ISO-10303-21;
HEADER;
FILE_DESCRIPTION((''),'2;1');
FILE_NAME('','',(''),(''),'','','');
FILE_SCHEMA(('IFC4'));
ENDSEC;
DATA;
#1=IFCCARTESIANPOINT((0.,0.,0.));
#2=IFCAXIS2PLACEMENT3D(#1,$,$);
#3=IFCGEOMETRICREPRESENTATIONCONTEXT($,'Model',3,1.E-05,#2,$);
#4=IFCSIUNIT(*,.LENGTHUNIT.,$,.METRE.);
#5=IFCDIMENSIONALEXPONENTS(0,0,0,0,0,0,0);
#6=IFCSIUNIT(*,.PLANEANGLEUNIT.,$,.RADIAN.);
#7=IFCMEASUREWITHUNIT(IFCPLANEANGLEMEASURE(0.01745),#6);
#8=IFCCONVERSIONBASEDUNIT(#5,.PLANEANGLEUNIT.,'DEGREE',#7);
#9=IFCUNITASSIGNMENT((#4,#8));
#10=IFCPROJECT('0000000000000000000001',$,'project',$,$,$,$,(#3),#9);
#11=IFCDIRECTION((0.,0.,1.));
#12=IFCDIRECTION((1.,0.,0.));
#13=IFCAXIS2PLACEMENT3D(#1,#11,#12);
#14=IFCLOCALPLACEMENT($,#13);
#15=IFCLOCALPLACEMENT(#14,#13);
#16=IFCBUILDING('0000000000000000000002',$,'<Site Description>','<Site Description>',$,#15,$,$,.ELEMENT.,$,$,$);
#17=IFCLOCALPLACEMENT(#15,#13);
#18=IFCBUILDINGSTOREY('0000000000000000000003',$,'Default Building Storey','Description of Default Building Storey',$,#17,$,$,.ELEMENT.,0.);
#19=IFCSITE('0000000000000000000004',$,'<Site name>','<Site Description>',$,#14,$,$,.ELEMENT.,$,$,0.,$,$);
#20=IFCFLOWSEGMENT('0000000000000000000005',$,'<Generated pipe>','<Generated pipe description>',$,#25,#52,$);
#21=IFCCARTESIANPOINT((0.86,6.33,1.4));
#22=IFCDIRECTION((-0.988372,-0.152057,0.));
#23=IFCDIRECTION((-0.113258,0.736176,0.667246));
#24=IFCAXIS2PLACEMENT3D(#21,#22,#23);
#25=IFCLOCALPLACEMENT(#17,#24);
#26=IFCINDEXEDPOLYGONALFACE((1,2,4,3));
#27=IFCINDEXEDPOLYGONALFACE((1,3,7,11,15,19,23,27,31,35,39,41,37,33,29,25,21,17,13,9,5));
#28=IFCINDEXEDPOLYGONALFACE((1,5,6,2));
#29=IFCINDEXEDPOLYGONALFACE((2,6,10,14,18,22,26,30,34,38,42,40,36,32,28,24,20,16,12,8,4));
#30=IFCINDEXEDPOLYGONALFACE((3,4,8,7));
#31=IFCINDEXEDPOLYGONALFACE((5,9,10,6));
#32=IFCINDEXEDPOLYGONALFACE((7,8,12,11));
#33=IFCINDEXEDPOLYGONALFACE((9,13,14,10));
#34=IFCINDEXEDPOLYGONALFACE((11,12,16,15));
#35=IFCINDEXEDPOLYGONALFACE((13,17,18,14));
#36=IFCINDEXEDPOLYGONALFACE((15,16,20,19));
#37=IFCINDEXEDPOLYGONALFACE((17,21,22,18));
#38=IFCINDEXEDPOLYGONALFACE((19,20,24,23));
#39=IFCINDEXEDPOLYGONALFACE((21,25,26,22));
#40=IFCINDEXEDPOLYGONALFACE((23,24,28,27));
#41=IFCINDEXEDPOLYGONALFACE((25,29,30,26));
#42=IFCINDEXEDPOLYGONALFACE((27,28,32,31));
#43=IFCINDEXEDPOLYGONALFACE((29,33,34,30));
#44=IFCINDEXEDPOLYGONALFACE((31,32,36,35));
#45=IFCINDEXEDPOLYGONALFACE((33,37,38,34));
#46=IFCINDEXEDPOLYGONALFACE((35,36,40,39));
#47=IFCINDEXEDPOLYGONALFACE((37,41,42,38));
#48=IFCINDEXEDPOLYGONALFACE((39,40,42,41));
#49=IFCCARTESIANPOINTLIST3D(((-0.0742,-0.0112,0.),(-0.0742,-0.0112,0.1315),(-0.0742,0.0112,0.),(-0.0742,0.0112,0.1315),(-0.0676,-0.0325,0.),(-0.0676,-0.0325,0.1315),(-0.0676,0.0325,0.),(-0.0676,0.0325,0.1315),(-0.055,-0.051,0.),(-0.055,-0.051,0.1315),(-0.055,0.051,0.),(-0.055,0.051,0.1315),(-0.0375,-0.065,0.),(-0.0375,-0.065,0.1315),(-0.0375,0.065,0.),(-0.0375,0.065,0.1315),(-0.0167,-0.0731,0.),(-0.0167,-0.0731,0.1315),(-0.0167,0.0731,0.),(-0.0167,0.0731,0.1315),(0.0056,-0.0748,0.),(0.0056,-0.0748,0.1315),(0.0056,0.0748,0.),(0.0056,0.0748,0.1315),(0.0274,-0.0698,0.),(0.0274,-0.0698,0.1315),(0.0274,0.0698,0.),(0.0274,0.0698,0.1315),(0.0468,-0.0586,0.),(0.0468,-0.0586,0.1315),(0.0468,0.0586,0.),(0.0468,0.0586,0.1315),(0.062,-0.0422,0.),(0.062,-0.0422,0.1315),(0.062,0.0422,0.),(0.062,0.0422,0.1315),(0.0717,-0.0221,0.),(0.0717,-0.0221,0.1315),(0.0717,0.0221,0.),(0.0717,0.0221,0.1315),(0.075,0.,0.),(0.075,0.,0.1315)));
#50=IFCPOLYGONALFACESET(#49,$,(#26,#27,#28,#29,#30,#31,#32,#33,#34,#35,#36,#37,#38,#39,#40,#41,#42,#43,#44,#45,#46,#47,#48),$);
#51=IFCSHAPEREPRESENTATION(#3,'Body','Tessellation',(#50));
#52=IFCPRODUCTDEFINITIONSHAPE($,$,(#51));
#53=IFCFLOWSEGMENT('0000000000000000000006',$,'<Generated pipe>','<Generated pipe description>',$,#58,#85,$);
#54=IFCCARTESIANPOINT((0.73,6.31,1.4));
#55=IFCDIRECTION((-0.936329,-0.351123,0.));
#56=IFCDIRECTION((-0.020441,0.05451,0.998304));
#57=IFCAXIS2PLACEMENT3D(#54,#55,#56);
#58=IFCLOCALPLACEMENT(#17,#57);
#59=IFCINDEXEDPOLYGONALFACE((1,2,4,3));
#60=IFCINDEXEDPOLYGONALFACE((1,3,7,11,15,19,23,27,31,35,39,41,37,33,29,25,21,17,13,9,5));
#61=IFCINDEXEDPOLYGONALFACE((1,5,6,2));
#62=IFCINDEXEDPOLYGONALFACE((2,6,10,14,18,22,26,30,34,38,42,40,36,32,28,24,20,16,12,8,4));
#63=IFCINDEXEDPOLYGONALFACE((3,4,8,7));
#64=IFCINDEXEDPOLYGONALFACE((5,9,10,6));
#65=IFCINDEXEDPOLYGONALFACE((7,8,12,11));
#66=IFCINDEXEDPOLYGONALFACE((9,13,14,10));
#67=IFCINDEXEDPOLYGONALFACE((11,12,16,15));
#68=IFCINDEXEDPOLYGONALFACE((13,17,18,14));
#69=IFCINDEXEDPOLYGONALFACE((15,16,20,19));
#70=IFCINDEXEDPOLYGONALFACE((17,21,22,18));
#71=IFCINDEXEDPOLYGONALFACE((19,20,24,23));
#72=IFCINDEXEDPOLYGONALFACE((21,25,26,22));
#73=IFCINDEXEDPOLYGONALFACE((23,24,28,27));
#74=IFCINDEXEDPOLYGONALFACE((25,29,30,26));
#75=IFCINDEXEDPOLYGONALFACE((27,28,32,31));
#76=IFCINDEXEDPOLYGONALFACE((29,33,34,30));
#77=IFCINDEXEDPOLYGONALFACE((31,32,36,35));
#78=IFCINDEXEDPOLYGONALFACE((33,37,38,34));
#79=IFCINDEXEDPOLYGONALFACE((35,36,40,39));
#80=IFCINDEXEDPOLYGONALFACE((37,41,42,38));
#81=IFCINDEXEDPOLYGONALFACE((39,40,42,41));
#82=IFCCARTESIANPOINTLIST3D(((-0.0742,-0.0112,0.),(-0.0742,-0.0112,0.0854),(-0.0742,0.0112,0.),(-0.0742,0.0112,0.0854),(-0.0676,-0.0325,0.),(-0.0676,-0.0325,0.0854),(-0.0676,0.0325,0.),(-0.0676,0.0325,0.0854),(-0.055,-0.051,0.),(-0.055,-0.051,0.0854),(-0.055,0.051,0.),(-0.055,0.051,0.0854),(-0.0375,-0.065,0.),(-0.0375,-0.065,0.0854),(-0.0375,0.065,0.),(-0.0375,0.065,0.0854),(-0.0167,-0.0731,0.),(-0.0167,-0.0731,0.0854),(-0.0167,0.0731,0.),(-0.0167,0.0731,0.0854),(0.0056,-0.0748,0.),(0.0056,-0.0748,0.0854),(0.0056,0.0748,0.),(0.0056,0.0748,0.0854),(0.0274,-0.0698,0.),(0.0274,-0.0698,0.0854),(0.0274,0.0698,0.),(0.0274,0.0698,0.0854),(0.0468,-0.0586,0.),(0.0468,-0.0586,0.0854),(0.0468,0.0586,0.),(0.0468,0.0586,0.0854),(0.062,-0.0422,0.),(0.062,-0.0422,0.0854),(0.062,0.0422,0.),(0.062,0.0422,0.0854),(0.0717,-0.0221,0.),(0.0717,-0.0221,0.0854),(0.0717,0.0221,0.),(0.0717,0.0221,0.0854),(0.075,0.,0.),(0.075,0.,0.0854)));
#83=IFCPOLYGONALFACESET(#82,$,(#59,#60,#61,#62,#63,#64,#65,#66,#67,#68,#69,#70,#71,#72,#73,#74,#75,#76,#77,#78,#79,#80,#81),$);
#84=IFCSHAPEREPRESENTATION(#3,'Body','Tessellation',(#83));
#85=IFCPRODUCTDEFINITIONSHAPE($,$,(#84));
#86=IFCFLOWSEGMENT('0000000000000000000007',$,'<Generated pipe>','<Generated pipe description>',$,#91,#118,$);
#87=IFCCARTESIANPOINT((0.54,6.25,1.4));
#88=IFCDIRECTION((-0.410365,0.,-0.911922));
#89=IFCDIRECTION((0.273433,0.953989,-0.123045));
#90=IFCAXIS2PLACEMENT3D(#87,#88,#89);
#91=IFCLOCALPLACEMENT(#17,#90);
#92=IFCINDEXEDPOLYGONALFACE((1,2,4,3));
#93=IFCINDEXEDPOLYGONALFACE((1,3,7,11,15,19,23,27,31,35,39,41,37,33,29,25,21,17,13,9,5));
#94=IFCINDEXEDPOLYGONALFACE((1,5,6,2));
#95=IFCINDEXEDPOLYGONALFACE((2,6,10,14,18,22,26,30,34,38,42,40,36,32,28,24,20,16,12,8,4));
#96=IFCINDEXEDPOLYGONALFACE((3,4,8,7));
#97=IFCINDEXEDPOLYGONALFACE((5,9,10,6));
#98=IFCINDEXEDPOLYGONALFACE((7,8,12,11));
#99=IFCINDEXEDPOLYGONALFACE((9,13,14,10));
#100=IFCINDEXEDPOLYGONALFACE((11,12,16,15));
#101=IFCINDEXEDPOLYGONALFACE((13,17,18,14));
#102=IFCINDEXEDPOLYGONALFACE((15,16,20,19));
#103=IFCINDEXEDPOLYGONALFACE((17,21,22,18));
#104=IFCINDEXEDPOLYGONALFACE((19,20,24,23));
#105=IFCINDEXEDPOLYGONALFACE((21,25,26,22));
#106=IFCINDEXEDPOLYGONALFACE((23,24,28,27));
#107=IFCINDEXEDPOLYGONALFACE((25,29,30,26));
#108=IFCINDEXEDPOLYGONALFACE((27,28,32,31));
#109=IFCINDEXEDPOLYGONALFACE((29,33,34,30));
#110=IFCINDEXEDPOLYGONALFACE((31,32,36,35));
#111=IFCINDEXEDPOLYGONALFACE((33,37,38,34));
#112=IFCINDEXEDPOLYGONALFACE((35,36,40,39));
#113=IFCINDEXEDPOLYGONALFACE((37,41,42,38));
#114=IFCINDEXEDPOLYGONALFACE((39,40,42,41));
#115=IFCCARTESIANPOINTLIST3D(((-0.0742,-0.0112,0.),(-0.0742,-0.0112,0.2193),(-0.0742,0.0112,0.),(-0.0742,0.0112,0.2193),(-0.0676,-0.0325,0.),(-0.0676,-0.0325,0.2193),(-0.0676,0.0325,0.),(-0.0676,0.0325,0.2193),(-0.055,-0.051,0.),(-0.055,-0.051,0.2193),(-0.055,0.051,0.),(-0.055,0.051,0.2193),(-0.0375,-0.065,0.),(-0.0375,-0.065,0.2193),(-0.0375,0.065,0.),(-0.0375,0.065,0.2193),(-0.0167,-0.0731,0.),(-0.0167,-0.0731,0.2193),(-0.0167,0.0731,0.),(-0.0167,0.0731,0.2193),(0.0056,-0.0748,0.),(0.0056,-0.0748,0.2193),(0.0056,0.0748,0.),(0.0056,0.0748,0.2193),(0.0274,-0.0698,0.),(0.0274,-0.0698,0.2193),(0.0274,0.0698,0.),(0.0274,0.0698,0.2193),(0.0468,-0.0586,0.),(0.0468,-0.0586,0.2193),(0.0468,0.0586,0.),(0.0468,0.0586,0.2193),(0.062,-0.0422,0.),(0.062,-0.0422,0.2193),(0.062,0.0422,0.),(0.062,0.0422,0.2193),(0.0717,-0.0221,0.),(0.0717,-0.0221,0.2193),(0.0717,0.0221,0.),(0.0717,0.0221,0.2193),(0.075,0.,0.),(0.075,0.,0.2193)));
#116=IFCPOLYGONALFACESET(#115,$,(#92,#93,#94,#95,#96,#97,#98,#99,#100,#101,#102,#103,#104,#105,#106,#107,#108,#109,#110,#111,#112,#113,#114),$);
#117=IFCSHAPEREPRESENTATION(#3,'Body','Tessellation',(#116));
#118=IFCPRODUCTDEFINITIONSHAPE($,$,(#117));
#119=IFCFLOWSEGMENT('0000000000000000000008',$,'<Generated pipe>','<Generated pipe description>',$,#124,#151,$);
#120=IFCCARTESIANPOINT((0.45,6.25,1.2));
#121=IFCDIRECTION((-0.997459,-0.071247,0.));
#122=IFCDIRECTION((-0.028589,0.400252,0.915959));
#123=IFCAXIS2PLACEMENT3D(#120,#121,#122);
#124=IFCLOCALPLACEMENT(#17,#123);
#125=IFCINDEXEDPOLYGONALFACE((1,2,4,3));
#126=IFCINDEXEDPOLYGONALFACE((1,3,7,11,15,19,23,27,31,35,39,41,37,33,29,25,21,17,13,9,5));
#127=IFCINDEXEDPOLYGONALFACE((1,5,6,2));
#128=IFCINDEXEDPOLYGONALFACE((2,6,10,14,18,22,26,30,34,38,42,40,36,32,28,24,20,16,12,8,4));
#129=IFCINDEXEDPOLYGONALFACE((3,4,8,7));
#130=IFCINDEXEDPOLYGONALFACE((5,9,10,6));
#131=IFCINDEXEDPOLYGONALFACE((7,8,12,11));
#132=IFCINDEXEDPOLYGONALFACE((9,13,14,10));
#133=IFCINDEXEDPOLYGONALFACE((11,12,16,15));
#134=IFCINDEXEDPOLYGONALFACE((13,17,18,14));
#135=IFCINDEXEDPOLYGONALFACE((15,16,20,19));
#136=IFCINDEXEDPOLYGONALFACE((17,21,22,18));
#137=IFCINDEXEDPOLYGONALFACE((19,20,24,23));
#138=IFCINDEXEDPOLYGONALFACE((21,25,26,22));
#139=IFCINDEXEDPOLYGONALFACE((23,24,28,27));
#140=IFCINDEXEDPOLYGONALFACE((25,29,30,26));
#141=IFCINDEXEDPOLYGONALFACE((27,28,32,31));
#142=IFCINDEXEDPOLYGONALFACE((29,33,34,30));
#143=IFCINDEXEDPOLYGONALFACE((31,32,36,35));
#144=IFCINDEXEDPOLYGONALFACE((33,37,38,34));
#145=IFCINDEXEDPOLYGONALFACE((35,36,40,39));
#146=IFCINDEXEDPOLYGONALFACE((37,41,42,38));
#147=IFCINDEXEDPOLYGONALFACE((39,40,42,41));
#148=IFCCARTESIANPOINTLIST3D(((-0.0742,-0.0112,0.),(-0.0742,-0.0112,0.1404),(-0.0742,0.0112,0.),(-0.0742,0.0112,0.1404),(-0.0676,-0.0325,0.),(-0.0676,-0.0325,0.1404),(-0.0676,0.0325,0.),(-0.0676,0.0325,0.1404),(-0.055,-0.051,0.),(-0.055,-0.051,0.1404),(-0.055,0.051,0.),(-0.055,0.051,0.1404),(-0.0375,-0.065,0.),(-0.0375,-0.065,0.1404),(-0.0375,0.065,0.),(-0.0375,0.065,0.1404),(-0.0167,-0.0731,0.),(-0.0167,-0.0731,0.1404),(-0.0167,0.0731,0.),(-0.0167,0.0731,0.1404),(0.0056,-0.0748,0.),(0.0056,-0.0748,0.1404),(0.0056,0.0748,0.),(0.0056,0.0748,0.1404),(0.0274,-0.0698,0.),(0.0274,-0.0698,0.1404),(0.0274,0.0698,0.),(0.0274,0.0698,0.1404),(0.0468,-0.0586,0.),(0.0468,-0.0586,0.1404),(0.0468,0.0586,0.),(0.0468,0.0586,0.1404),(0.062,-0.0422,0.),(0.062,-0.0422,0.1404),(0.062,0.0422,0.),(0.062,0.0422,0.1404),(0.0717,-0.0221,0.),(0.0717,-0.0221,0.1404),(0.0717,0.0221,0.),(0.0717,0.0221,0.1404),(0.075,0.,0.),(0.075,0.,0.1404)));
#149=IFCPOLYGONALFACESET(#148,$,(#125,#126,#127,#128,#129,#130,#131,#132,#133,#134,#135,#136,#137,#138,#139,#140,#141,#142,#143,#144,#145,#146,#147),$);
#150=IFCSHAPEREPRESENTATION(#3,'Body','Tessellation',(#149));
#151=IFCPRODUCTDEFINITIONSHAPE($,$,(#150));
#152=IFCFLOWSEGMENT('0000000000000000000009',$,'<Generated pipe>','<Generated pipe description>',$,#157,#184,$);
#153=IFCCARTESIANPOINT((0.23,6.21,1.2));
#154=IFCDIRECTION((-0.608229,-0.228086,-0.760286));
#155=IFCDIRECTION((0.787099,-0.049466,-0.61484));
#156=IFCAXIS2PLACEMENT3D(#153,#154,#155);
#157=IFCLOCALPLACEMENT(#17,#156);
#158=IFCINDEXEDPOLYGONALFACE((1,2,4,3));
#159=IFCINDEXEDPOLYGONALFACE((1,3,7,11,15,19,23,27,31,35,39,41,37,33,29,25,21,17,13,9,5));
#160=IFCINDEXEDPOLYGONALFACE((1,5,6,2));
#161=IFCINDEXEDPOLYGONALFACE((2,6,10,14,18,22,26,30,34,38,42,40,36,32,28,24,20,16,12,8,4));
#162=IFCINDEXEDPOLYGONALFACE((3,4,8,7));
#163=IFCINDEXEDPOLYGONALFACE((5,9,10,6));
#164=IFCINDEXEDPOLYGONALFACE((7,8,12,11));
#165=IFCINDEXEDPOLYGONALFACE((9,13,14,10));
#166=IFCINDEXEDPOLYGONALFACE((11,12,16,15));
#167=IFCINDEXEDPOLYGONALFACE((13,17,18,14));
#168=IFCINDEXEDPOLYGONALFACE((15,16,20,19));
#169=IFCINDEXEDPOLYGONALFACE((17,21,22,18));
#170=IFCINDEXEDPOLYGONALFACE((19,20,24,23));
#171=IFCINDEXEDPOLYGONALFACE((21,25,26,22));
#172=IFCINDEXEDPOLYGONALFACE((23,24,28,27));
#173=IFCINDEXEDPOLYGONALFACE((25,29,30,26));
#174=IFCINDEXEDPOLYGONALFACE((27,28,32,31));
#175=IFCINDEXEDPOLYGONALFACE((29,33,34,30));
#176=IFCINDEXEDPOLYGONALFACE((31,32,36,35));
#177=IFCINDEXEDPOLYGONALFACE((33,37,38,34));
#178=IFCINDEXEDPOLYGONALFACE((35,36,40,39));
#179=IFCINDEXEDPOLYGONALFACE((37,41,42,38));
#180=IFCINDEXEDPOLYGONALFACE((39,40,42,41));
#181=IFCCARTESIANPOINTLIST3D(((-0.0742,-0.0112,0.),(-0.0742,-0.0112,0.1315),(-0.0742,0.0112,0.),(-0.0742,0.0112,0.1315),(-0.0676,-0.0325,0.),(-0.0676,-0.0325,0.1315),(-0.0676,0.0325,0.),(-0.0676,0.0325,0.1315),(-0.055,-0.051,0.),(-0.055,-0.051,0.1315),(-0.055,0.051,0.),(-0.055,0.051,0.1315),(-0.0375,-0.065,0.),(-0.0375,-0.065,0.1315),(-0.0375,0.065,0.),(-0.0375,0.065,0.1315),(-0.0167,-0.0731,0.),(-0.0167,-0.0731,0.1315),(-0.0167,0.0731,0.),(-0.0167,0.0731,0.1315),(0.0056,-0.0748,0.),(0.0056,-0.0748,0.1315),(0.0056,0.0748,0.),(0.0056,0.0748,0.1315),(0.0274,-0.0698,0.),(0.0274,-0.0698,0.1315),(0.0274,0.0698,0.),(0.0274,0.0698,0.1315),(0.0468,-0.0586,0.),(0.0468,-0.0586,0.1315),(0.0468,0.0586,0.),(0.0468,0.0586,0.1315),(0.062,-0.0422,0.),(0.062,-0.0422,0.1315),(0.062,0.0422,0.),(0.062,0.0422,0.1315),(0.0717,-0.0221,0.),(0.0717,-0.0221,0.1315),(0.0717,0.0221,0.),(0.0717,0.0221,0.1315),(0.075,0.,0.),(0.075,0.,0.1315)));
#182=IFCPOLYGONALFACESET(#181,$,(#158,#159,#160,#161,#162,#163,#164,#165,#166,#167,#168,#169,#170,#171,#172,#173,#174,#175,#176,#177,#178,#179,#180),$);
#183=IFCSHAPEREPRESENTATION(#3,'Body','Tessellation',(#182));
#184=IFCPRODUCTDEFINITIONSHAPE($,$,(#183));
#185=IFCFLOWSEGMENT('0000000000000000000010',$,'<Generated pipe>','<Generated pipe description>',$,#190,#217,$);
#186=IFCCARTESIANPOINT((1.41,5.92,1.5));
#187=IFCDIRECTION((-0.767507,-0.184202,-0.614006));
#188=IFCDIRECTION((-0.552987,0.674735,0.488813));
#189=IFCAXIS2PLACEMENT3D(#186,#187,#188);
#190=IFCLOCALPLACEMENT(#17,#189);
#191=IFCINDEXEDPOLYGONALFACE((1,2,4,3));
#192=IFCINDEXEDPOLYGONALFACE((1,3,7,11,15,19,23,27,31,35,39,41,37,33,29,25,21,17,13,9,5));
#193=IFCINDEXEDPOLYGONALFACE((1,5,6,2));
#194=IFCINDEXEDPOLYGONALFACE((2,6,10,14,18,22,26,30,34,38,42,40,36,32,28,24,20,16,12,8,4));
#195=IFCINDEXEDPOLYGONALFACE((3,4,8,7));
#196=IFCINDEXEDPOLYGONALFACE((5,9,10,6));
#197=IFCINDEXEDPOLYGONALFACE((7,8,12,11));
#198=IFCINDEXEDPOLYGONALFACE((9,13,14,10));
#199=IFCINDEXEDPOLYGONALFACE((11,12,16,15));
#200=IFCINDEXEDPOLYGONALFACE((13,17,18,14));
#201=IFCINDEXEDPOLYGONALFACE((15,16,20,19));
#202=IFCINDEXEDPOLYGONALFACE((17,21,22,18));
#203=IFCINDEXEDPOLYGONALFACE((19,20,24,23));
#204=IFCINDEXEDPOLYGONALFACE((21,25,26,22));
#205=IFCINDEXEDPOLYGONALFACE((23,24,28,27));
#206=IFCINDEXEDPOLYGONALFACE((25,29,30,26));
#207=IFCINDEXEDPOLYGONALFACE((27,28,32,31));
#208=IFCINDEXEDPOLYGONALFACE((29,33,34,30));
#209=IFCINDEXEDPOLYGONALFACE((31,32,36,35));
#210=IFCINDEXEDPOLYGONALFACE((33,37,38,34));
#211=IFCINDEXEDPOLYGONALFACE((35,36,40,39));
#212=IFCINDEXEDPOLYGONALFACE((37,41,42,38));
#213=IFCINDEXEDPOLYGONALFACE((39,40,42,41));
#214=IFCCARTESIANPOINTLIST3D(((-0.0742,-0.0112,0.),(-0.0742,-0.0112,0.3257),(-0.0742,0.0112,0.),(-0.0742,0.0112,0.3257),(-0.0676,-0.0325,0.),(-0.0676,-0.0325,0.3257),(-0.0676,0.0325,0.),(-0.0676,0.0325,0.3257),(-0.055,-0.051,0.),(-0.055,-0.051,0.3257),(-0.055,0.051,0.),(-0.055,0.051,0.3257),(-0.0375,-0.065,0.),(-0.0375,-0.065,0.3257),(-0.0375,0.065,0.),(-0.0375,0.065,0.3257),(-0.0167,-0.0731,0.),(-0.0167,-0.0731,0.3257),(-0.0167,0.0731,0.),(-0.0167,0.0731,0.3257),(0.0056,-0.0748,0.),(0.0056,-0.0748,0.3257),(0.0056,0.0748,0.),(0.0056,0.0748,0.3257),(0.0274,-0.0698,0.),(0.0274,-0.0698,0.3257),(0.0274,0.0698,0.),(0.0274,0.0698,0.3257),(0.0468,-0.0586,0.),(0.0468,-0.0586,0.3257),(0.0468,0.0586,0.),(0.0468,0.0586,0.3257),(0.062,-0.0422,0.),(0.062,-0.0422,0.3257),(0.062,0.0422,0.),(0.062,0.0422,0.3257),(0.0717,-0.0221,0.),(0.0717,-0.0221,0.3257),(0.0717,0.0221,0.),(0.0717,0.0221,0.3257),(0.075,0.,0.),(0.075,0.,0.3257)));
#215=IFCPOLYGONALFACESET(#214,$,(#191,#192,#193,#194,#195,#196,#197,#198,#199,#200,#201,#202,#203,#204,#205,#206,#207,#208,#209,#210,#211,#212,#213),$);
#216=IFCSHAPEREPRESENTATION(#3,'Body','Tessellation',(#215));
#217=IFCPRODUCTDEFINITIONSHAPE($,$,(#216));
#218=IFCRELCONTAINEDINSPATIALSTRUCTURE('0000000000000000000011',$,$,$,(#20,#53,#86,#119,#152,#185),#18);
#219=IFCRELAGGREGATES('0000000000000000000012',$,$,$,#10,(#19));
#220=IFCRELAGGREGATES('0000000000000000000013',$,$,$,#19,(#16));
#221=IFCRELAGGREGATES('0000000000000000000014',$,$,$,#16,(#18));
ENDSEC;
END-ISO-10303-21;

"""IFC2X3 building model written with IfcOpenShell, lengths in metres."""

from ifc_helpers import new_model, entity, si_unit, converted_unit, frame, origin, origin_with_axes, origin_2d_with_axis, place, context, project, spatial, circle, extrude, element, save


model = new_model("IFC2X3")

# Units and contexts
model_context = context("Model", 3, precision=1e-05, world=origin())
ifc_project = project(units=[si_unit("LENGTHUNIT", "METRE"), converted_unit("PLANEANGLEUNIT", "DEGREE", entity("IfcPlaneAngleMeasure", 0.01745), si_unit("PLANEANGLEUNIT", "RADIAN"), dimensions=[0, 0, 0, 0, 0, 0, 0])], contexts=[model_context])

# Site, building, storey
site_placement = place(None, origin_with_axes())
site = spatial("IfcSite", under=ifc_project, at=site_placement, Name="<Site name>", Description="<Site Description>", CompositionType="ELEMENT", RefElevation=0.0)
building_placement = place(site_placement, origin_with_axes())
building = spatial("IfcBuilding", under=site, at=building_placement, Name="<Site Description>", Description="<Site Description>", CompositionType="ELEMENT")
storey_placement = place(building_placement, origin_with_axes())
storey = spatial("IfcBuildingStorey", under=building, at=storey_placement, Name="Default Building Storey", Description="Description of Default Building Storey", CompositionType="ELEMENT", Elevation=0.0)

# Flow segments
flow_segment_1_placement = place(storey_placement, frame((0.86, 6.33, 1.4), z_axis=(-0.988372, -0.152057, 0.0), x_axis=(-0.113258, 0.736176, 0.667246)))
element("IfcFlowSegment", 1, at=flow_segment_1_placement, inside=storey, Name="<Generated pipe>", Description="<Generated pipe description>", context=model_context, shape_type="SweptSolid", body=[
    extrude(circle(Radius=0.075, at=origin_2d_with_axis()), origin_with_axes(), (0.0, 0.0, 1.0), 0.1315),
])
flow_segment_2_placement = place(storey_placement, frame((0.73, 6.31, 1.4), z_axis=(-0.936329, -0.351123, 0.0), x_axis=(-0.020441, 0.05451, 0.998304)))
element("IfcFlowSegment", 2, at=flow_segment_2_placement, inside=storey, Name="<Generated pipe>", Description="<Generated pipe description>", context=model_context, shape_type="SweptSolid", body=[
    extrude(circle(Radius=0.075, at=origin_2d_with_axis()), origin_with_axes(), (0.0, 0.0, 1.0), 0.0854),
])
flow_segment_3_placement = place(storey_placement, frame((0.54, 6.25, 1.4), z_axis=(-0.410365, 0.0, -0.911922), x_axis=(0.273433, 0.953989, -0.123045)))
element("IfcFlowSegment", 3, at=flow_segment_3_placement, inside=storey, Name="<Generated pipe>", Description="<Generated pipe description>", context=model_context, shape_type="SweptSolid", body=[
    extrude(circle(Radius=0.075, at=origin_2d_with_axis()), origin_with_axes(), (0.0, 0.0, 1.0), 0.2193),
])
flow_segment_4_placement = place(storey_placement, frame((0.45, 6.25, 1.2), z_axis=(-0.997459, -0.071247, 0.0), x_axis=(-0.028589, 0.400252, 0.915959)))
element("IfcFlowSegment", 4, at=flow_segment_4_placement, inside=storey, Name="<Generated pipe>", Description="<Generated pipe description>", context=model_context, shape_type="SweptSolid", body=[
    extrude(circle(Radius=0.075, at=origin_2d_with_axis()), origin_with_axes(), (0.0, 0.0, 1.0), 0.1404),
])
flow_segment_5_placement = place(storey_placement, frame((0.23, 6.21, 1.2), z_axis=(-0.608229, -0.228086, -0.760286), x_axis=(0.787099, -0.049466, -0.61484)))
element("IfcFlowSegment", 5, at=flow_segment_5_placement, inside=storey, Name="<Generated pipe>", Description="<Generated pipe description>", context=model_context, shape_type="SweptSolid", body=[
    extrude(circle(Radius=0.075, at=origin_2d_with_axis()), origin_with_axes(), (0.0, 0.0, 1.0), 0.1315),
])
flow_segment_6_placement = place(storey_placement, frame((1.41, 5.92, 1.5), z_axis=(-0.767507, -0.184202, -0.614006), x_axis=(-0.552987, 0.674735, 0.488813)))
element("IfcFlowSegment", 6, at=flow_segment_6_placement, inside=storey, Name="<Generated pipe>", Description="<Generated pipe description>", context=model_context, shape_type="SweptSolid", body=[
    extrude(circle(Radius=0.075, at=origin_2d_with_axis()), origin_with_axes(), (0.0, 0.0, 1.0), 0.3257),
])

save(model, "model.ifc")
